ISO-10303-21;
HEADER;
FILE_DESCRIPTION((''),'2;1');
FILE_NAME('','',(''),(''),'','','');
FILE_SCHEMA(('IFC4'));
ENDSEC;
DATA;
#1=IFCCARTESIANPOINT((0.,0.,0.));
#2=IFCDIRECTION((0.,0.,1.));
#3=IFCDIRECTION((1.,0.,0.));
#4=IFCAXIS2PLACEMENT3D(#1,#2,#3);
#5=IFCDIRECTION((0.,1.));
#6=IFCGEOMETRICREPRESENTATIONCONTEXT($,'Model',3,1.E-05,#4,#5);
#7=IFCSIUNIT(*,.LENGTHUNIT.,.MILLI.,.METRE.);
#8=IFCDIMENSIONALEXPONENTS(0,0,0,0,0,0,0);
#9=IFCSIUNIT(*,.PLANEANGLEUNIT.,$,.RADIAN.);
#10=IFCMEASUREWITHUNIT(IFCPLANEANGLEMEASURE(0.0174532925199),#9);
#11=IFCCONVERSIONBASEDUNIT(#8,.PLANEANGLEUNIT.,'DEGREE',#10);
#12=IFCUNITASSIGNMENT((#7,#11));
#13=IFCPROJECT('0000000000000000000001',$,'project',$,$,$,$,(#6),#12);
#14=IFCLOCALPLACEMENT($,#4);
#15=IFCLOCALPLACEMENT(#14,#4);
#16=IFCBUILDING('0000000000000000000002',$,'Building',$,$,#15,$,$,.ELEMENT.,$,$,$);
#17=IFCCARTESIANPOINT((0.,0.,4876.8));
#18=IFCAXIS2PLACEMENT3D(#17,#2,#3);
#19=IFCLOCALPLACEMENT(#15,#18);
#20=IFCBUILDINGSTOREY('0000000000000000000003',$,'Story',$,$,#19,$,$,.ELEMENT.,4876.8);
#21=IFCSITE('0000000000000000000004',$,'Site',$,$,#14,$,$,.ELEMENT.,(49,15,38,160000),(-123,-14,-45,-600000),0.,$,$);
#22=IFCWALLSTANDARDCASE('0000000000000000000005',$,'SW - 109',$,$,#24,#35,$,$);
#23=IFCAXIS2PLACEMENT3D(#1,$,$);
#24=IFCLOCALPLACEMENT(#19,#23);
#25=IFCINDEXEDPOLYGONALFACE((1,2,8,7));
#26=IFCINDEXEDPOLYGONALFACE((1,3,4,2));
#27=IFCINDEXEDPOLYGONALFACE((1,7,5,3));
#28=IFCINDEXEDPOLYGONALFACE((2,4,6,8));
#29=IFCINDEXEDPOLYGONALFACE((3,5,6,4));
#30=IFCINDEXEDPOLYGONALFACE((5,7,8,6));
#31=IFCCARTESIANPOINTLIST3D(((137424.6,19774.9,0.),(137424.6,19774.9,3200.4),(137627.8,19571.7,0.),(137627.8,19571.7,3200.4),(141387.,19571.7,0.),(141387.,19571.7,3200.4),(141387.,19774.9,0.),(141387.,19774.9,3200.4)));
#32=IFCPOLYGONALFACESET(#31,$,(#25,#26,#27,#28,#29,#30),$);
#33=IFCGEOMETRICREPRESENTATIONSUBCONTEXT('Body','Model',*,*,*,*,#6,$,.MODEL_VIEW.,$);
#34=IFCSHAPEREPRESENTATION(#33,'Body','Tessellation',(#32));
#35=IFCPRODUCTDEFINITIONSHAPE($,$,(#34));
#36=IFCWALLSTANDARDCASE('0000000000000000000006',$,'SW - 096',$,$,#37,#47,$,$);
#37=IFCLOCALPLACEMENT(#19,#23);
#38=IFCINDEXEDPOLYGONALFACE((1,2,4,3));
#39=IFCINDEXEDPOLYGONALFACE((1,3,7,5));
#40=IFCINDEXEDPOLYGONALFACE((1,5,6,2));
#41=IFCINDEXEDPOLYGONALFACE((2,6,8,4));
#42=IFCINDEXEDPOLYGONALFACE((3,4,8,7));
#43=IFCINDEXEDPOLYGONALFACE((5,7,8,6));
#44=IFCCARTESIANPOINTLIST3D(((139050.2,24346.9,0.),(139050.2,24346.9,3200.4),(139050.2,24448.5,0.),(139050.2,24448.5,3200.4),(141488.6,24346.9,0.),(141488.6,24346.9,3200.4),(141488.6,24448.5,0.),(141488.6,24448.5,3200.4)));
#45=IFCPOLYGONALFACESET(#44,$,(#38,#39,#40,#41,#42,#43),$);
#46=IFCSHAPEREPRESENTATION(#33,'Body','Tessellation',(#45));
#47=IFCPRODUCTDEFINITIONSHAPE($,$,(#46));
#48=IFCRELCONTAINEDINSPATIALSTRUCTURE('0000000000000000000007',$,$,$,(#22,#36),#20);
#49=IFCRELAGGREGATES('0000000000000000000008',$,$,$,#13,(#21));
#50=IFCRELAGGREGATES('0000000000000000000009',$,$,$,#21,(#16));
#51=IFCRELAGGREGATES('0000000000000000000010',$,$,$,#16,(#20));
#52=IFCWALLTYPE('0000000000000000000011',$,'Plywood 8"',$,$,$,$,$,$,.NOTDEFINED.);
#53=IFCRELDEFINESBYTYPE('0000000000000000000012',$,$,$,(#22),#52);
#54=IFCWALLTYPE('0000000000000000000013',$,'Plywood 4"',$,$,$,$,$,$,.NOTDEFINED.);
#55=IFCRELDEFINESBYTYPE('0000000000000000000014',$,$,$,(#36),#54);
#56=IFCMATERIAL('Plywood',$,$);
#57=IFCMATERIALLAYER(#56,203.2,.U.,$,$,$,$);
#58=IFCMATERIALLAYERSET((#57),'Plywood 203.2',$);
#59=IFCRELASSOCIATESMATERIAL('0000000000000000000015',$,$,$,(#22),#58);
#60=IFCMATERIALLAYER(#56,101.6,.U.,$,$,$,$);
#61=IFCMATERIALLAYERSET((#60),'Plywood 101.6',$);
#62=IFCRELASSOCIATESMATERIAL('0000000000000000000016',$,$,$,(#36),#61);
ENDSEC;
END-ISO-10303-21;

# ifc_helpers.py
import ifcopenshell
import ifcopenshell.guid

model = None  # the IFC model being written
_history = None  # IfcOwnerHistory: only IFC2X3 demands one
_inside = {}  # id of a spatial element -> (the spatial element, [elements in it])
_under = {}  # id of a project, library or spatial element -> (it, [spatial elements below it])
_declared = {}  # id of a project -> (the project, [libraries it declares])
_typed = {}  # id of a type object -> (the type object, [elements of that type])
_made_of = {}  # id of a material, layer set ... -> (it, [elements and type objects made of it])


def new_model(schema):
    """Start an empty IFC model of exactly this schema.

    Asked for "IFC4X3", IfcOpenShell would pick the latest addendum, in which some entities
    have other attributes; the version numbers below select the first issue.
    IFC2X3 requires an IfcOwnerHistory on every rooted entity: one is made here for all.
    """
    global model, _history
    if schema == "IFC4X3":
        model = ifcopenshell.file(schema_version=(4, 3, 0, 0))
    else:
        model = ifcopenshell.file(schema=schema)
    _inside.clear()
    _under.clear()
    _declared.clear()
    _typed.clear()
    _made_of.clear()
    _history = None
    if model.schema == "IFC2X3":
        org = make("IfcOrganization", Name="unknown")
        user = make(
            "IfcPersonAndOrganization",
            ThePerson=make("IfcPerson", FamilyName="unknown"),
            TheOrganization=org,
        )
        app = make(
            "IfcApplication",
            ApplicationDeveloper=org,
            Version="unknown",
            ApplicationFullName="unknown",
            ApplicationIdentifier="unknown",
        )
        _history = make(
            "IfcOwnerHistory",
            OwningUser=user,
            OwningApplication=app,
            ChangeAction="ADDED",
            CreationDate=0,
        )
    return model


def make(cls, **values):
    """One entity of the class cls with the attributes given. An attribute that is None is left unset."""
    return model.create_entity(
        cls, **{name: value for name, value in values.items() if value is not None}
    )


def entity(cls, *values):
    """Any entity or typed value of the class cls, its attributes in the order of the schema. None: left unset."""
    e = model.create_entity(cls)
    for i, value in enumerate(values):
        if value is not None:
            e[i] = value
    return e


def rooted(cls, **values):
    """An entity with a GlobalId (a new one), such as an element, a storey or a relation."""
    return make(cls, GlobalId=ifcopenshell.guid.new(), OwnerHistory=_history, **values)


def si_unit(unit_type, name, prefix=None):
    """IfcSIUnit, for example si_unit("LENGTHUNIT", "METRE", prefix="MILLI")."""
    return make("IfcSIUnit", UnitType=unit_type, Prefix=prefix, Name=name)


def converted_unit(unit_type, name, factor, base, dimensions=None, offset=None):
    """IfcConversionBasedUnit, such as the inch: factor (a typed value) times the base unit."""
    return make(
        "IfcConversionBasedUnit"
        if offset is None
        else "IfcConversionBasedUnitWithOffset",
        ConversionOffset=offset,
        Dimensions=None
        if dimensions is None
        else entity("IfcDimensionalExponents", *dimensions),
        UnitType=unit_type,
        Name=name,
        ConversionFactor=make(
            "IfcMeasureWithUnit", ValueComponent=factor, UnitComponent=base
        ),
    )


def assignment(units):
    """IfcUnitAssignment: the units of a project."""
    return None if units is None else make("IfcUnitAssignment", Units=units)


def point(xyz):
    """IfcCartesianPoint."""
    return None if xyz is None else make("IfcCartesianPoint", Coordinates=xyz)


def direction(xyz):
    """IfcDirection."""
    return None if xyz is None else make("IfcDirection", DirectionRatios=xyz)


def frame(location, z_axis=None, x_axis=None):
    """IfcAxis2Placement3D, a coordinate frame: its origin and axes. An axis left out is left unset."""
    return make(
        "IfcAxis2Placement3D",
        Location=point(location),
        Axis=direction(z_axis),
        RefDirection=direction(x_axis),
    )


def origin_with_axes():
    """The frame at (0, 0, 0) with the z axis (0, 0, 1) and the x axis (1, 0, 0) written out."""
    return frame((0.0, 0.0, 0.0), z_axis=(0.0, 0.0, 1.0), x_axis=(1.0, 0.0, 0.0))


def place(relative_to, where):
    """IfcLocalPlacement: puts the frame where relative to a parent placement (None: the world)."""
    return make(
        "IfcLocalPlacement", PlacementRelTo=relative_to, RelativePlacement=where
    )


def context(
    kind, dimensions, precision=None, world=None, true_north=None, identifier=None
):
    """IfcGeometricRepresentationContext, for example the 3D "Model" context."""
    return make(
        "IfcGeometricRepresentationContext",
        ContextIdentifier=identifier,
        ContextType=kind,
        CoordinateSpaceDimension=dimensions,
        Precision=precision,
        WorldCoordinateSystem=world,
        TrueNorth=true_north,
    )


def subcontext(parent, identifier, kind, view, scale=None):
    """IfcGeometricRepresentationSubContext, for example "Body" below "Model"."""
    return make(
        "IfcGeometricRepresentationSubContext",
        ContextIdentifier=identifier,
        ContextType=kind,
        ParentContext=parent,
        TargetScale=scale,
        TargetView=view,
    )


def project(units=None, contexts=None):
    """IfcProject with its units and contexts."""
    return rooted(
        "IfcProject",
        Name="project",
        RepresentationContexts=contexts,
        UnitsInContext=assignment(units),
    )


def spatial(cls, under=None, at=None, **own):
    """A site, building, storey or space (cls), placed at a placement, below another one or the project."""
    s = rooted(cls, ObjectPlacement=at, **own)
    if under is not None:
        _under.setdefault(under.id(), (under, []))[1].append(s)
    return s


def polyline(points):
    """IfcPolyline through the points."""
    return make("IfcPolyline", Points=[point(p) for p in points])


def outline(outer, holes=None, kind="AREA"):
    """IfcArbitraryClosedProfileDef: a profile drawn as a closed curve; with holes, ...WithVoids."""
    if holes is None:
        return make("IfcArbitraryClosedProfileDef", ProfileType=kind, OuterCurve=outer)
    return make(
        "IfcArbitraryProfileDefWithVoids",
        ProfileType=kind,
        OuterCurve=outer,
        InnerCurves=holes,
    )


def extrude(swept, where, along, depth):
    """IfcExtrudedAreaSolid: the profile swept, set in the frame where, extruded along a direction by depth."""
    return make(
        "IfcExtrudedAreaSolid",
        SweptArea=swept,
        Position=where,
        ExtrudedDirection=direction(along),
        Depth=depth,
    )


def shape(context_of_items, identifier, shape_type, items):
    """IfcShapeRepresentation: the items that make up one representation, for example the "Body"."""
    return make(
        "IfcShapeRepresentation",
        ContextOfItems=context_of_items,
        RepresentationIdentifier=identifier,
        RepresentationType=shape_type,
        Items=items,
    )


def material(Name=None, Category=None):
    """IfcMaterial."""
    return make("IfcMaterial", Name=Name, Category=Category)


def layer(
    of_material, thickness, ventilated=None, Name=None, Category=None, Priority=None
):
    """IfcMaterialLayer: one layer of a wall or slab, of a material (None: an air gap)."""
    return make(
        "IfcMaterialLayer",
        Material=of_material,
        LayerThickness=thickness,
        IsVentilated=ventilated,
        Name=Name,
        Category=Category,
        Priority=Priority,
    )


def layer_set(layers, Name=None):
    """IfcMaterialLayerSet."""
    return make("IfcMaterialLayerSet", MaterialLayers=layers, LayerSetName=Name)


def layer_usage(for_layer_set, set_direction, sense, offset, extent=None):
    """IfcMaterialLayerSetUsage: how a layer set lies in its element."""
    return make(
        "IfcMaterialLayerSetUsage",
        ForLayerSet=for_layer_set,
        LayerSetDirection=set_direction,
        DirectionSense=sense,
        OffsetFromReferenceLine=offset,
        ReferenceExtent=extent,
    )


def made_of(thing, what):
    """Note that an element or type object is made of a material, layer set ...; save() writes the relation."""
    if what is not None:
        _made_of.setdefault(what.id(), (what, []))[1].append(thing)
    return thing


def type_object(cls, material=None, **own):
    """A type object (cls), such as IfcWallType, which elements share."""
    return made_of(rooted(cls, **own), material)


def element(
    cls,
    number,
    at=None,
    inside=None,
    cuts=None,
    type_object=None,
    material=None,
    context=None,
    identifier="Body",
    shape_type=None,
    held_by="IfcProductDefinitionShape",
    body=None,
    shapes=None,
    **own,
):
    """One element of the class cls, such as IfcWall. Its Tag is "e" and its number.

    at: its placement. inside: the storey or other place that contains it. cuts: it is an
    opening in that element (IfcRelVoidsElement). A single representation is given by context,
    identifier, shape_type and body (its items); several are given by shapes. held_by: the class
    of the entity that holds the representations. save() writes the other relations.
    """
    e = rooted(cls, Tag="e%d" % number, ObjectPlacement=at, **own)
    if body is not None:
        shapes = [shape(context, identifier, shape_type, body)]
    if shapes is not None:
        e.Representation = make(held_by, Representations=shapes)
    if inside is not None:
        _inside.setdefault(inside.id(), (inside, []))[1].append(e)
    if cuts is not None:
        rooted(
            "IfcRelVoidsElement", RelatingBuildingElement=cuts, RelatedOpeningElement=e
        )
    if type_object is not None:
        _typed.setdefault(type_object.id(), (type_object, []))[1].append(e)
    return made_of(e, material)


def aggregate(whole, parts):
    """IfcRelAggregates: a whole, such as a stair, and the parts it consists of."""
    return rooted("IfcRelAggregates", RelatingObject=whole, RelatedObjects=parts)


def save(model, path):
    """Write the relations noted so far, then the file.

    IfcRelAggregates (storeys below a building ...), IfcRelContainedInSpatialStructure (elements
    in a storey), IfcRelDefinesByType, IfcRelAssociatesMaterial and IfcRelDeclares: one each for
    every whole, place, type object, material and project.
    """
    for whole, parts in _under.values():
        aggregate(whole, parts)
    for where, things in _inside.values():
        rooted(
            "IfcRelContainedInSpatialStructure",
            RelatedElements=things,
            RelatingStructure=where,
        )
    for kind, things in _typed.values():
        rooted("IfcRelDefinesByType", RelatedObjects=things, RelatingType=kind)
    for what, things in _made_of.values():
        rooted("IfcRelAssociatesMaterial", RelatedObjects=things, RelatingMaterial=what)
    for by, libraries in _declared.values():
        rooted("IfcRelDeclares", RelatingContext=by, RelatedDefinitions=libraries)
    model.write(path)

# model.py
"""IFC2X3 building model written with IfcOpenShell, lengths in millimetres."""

from ifc_helpers import new_model, entity, si_unit, converted_unit, direction, frame, origin_with_axes, place, context, subcontext, project, spatial, polyline, outline, extrude, material, layer, layer_set, layer_usage, type_object, element, save


model = new_model("IFC2X3")

# Units and contexts
model_context = context("Model", 3, precision=1e-05, world=origin_with_axes(), true_north=direction((0.0, 1.0)))
body_context = subcontext(model_context, "Body", "Model", "MODEL_VIEW")
ifc_project = project(units=[si_unit("LENGTHUNIT", "METRE", prefix="MILLI"), converted_unit("PLANEANGLEUNIT", "DEGREE", entity("IfcPlaneAngleMeasure", 0.0174532925199), si_unit("PLANEANGLEUNIT", "RADIAN"), dimensions=[0, 0, 0, 0, 0, 0, 0])], contexts=[model_context])

# Site, building, storey
site_placement = place(None, origin_with_axes())
site = spatial("IfcSite", under=ifc_project, at=site_placement, Name="Site", CompositionType="ELEMENT", RefLatitude=(49, 15, 38, 160000), RefLongitude=(-123, -14, -45, -600000), RefElevation=0.0)
building_placement = place(site_placement, origin_with_axes())
building = spatial("IfcBuilding", under=site, at=building_placement, Name="Building", CompositionType="ELEMENT")
storey_placement = place(building_placement, frame((0.0, 0.0, 4876.8), z_axis=(0.0, 0.0, 1.0), x_axis=(1.0, 0.0, 0.0)))
storey = spatial("IfcBuildingStorey", under=building, at=storey_placement, Name="Story", CompositionType="ELEMENT", Elevation=4876.8)

# Shared definitions
ifc_material_1 = material(Name="Plywood")
ifc_layer_1 = layer(ifc_material_1, 203.2, ventilated="UNKNOWN")
ifc_layer_set_1 = layer_set([ifc_layer_1], Name="Plywood 203.2")
wall_type_1 = type_object("IfcWallType", Name="Plywood 8\"", PredefinedType="NOTDEFINED")

# Wall
ifc_layer_usage_1 = layer_usage(ifc_layer_set_1, "AXIS2", "POSITIVE", 0.0)
wall_1_placement = place(storey_placement, frame((141387.0, 19774.9, 0.0), z_axis=(0.0, 0.0, 1.0), x_axis=(-1.0, 0.0, 0.0)))
element("IfcWallStandardCase", 1, at=wall_1_placement, inside=storey, type_object=wall_type_1, material=ifc_layer_usage_1, Name="SW - 109", context=body_context, shape_type="SweptSolid", body=[
    extrude(outline(polyline([(0.0, 0.0), (3962.4, 0.0), (3759.2, 203.2), (0.0, 203.2), (0.0, 0.0)])), origin_with_axes(), (0.0, 0.0, 1.0), 3200.4),
])

# Wall
ifc_layer_2 = layer(ifc_material_1, 101.6, ventilated="UNKNOWN")
ifc_layer_set_2 = layer_set([ifc_layer_2], Name="Plywood 101.6")
ifc_layer_usage_2 = layer_usage(ifc_layer_set_2, "AXIS2", "POSITIVE", 0.0)
wall_type_2 = type_object("IfcWallType", Name="Plywood 4\"", PredefinedType="NOTDEFINED")
wall_2_placement = place(storey_placement, frame((141488.6, 24448.5, 0.0), z_axis=(0.0, 0.0, 1.0), x_axis=(-1.0, 0.0, 0.0)))
element("IfcWallStandardCase", 2, at=wall_2_placement, inside=storey, type_object=wall_type_2, material=ifc_layer_usage_2, Name="SW - 096", context=body_context, shape_type="SweptSolid", body=[
    extrude(outline(polyline([(0.0, 0.0), (2438.4, 0.0), (2438.4, 101.6), (0.0, 101.6), (0.0, 0.0)])), origin_with_axes(), (0.0, 0.0, 1.0), 3200.4),
])

save(model, "model.ifc")
